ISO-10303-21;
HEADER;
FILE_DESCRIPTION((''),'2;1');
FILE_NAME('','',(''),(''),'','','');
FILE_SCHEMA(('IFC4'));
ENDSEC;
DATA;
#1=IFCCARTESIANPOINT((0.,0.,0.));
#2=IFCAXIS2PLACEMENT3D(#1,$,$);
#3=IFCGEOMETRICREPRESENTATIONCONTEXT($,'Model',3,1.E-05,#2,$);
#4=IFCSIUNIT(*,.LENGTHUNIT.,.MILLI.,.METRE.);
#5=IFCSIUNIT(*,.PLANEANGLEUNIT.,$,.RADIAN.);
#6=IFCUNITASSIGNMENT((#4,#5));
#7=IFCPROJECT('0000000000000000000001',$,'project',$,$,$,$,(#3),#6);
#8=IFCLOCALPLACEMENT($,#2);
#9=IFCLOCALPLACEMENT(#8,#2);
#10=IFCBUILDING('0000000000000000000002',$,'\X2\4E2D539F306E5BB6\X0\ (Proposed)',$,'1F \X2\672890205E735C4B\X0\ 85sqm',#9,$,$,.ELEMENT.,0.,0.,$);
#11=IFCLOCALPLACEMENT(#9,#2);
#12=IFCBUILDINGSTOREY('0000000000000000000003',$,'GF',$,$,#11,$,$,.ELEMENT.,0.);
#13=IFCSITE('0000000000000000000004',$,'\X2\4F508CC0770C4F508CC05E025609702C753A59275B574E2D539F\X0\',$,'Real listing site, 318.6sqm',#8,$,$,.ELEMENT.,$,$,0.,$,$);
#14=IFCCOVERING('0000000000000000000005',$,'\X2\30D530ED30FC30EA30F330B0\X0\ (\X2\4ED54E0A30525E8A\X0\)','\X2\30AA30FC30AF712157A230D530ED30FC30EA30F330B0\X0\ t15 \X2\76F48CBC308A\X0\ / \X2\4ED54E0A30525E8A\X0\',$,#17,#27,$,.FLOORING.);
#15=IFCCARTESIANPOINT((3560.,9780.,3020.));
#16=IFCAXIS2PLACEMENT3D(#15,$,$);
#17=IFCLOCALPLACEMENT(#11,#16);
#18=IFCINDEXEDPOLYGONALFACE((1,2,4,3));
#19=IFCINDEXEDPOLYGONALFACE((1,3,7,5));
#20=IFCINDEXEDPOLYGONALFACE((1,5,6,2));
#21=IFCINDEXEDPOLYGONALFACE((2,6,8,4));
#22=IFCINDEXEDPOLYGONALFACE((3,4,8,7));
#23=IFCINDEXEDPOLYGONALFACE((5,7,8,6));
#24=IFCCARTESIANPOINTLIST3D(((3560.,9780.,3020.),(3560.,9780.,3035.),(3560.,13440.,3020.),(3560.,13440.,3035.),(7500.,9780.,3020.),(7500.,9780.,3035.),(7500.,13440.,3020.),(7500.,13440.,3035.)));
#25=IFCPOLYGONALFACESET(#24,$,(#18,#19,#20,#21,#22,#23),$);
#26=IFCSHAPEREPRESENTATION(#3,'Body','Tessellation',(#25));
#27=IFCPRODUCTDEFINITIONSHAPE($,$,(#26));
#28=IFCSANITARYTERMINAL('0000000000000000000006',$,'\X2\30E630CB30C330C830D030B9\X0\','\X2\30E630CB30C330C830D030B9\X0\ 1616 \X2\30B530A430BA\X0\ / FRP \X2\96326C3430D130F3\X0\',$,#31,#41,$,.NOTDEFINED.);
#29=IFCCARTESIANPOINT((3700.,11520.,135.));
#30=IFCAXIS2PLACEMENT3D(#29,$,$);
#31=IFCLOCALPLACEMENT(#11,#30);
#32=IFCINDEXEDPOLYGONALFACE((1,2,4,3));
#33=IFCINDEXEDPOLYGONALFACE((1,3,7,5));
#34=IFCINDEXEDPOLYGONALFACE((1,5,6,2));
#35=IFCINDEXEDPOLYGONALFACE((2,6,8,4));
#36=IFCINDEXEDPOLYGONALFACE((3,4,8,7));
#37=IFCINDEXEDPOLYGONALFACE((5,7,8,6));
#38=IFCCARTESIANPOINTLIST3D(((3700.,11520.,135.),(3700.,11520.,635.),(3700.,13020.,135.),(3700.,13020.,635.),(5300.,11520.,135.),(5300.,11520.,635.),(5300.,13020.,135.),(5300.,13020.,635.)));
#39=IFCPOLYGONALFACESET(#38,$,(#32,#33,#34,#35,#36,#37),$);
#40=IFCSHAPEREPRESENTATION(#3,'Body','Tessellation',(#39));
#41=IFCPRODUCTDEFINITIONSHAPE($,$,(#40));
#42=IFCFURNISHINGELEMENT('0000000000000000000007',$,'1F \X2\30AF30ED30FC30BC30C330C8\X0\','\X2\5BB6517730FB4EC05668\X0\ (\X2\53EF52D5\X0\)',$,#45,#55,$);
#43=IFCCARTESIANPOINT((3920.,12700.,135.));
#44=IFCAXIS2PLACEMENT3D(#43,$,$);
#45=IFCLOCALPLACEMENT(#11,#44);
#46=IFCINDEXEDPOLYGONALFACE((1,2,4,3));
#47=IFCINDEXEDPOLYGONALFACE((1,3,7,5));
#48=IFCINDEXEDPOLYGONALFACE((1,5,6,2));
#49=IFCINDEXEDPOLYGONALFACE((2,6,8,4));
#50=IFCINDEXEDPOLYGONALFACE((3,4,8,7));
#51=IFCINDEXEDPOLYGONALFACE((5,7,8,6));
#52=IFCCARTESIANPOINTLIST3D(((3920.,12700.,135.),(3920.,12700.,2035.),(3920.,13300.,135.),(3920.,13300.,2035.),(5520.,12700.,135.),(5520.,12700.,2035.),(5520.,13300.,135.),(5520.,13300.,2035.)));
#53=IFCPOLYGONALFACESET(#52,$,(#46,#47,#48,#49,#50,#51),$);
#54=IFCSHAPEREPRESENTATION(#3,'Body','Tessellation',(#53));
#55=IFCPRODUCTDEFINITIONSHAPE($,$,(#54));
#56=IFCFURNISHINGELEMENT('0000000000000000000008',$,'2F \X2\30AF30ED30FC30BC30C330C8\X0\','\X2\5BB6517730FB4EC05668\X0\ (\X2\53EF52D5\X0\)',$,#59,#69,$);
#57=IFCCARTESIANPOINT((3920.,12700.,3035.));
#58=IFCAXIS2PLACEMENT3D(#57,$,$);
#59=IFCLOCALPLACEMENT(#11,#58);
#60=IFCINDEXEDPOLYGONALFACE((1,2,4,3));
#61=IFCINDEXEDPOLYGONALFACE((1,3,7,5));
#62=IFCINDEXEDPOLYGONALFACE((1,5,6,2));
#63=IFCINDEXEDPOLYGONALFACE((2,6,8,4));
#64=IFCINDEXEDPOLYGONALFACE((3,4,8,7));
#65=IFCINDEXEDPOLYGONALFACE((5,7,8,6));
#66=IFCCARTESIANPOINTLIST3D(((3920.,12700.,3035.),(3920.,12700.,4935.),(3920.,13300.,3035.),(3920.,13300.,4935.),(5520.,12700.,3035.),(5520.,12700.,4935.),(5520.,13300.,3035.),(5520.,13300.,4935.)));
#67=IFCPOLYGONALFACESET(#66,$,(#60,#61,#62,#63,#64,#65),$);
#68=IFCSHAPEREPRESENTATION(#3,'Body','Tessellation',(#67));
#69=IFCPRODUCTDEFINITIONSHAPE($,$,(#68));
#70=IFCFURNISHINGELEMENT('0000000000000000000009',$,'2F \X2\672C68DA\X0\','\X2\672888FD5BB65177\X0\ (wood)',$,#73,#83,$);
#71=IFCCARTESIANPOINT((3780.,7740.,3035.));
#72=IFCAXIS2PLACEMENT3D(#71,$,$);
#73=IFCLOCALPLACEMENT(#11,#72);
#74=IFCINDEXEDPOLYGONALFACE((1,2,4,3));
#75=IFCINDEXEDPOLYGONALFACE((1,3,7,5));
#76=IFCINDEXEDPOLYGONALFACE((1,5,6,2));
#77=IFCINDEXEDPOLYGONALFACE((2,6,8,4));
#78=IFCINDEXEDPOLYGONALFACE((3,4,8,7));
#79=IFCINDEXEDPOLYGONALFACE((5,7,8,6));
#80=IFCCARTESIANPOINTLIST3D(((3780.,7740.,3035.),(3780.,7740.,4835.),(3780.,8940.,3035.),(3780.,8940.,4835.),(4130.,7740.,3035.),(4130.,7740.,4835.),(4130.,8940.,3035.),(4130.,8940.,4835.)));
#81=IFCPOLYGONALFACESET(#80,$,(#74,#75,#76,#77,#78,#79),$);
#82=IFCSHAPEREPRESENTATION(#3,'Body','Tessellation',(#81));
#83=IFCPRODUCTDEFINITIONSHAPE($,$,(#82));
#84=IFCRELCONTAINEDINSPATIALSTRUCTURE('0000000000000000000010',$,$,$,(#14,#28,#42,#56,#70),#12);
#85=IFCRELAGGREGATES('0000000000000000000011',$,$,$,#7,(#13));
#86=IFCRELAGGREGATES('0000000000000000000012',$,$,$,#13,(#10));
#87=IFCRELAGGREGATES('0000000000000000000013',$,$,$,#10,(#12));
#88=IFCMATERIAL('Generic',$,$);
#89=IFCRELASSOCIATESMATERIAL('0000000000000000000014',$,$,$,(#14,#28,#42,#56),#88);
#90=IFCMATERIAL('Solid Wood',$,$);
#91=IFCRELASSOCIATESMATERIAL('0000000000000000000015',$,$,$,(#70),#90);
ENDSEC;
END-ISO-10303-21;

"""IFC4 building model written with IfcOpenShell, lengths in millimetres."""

from ifc_helpers import new_model, si_unit, frame, frame_2d, origin, place, context, project, spatial, rectangle, extrude, material, element, save


model = new_model("IFC4")

# Units and contexts
model_context = context("Model", 3, precision=1e-05, world=origin())
ifc_project = project(units=[si_unit("LENGTHUNIT", "METRE", prefix="MILLI"), si_unit("PLANEANGLEUNIT", "RADIAN")], contexts=[model_context])

# Site, building, storey
site_placement = place(None, origin())
site = spatial("IfcSite", under=ifc_project, at=site_placement, Name="佐賀県佐賀市嘉瀬町大字中原", ObjectType="Real listing site, 318.6sqm", CompositionType="ELEMENT", RefElevation=0.0)
building_placement = place(site_placement, origin())
building = spatial("IfcBuilding", under=site, at=building_placement, Name="中原の家 (Proposed)", ObjectType="1F 木造平屋 85sqm", CompositionType="ELEMENT", ElevationOfRefHeight=0.0, ElevationOfTerrain=0.0)
storey_placement = place(building_placement, origin())
storey = spatial("IfcBuildingStorey", under=building, at=storey_placement, Name="GF", CompositionType="ELEMENT", Elevation=0.0)

# Shared definitions
ifc_material_1 = material(Name="Solid Wood")

# Covering
ifc_material_2 = material(Name="Generic")
covering_1_placement = place(storey_placement, frame((3560.0, 9780.0, 3020.0)))
element("IfcCovering", 1, at=covering_1_placement, inside=storey, material=ifc_material_2, Name="フローリング (仕上げ床)", Description="オーク無垢フローリング t15 直貼り / 仕上げ床", PredefinedType="FLOORING", context=model_context, shape_type="SweptSolid", body=[
    extrude(rectangle(XDim=3940.0, YDim=3660.0, at=frame_2d((1970.0, 1830.0))), frame((3560.0, 9780.0, 3020.0)), (0.0, 0.0, 1.0), 15.0),
])

# Sanitary terminal
sanitary_terminal_placement = place(storey_placement, frame((3700.0, 11520.0, 135.0)))
element("IfcSanitaryTerminal", 2, at=sanitary_terminal_placement, inside=storey, material=ifc_material_2, Name="ユニットバス", Description="ユニットバス 1616 サイズ / FRP 防水パン", PredefinedType="NOTDEFINED", context=model_context, shape_type="SweptSolid", body=[
    extrude(rectangle(XDim=1600.0, YDim=1500.0, at=frame_2d((800.0, 750.0))), frame((3700.0, 11520.0, 135.0)), (0.0, 0.0, 1.0), 500.0),
])

# Furnishing elements
furnishing_1_placement = place(storey_placement, frame((3920.0, 12700.0, 135.0)))
element("IfcFurnishingElement", 3, at=furnishing_1_placement, inside=storey, material=ifc_material_2, Name="1F クローゼット", Description="家具・什器 (可動)", context=model_context, shape_type="SweptSolid", body=[
    extrude(rectangle(XDim=1600.0, YDim=600.0, at=frame_2d((800.0, 300.0))), frame((3920.0, 12700.0, 135.0)), (0.0, 0.0, 1.0), 1900.0),
])
furnishing_2_placement = place(storey_placement, frame((3920.0, 12700.0, 3035.0)))
element("IfcFurnishingElement", 4, at=furnishing_2_placement, inside=storey, material=ifc_material_2, Name="2F クローゼット", Description="家具・什器 (可動)", context=model_context, shape_type="SweptSolid", body=[
    extrude(rectangle(XDim=1600.0, YDim=600.0, at=frame_2d((800.0, 300.0))), frame((3920.0, 12700.0, 3035.0)), (0.0, 0.0, 1.0), 1900.0),
])
furnishing_3_placement = place(storey_placement, frame((3780.0, 7740.0, 3035.0)))
element("IfcFurnishingElement", 5, at=furnishing_3_placement, inside=storey, material=ifc_material_1, Name="2F 本棚", Description="木製家具 (wood)", context=model_context, shape_type="SweptSolid", body=[
    extrude(rectangle(XDim=350.0, YDim=1200.0, at=frame_2d((175.0, 600.0))), frame((3780.0, 7740.0, 3035.0)), (0.0, 0.0, 1.0), 1800.0),
])

save(model, "model.ifc")
